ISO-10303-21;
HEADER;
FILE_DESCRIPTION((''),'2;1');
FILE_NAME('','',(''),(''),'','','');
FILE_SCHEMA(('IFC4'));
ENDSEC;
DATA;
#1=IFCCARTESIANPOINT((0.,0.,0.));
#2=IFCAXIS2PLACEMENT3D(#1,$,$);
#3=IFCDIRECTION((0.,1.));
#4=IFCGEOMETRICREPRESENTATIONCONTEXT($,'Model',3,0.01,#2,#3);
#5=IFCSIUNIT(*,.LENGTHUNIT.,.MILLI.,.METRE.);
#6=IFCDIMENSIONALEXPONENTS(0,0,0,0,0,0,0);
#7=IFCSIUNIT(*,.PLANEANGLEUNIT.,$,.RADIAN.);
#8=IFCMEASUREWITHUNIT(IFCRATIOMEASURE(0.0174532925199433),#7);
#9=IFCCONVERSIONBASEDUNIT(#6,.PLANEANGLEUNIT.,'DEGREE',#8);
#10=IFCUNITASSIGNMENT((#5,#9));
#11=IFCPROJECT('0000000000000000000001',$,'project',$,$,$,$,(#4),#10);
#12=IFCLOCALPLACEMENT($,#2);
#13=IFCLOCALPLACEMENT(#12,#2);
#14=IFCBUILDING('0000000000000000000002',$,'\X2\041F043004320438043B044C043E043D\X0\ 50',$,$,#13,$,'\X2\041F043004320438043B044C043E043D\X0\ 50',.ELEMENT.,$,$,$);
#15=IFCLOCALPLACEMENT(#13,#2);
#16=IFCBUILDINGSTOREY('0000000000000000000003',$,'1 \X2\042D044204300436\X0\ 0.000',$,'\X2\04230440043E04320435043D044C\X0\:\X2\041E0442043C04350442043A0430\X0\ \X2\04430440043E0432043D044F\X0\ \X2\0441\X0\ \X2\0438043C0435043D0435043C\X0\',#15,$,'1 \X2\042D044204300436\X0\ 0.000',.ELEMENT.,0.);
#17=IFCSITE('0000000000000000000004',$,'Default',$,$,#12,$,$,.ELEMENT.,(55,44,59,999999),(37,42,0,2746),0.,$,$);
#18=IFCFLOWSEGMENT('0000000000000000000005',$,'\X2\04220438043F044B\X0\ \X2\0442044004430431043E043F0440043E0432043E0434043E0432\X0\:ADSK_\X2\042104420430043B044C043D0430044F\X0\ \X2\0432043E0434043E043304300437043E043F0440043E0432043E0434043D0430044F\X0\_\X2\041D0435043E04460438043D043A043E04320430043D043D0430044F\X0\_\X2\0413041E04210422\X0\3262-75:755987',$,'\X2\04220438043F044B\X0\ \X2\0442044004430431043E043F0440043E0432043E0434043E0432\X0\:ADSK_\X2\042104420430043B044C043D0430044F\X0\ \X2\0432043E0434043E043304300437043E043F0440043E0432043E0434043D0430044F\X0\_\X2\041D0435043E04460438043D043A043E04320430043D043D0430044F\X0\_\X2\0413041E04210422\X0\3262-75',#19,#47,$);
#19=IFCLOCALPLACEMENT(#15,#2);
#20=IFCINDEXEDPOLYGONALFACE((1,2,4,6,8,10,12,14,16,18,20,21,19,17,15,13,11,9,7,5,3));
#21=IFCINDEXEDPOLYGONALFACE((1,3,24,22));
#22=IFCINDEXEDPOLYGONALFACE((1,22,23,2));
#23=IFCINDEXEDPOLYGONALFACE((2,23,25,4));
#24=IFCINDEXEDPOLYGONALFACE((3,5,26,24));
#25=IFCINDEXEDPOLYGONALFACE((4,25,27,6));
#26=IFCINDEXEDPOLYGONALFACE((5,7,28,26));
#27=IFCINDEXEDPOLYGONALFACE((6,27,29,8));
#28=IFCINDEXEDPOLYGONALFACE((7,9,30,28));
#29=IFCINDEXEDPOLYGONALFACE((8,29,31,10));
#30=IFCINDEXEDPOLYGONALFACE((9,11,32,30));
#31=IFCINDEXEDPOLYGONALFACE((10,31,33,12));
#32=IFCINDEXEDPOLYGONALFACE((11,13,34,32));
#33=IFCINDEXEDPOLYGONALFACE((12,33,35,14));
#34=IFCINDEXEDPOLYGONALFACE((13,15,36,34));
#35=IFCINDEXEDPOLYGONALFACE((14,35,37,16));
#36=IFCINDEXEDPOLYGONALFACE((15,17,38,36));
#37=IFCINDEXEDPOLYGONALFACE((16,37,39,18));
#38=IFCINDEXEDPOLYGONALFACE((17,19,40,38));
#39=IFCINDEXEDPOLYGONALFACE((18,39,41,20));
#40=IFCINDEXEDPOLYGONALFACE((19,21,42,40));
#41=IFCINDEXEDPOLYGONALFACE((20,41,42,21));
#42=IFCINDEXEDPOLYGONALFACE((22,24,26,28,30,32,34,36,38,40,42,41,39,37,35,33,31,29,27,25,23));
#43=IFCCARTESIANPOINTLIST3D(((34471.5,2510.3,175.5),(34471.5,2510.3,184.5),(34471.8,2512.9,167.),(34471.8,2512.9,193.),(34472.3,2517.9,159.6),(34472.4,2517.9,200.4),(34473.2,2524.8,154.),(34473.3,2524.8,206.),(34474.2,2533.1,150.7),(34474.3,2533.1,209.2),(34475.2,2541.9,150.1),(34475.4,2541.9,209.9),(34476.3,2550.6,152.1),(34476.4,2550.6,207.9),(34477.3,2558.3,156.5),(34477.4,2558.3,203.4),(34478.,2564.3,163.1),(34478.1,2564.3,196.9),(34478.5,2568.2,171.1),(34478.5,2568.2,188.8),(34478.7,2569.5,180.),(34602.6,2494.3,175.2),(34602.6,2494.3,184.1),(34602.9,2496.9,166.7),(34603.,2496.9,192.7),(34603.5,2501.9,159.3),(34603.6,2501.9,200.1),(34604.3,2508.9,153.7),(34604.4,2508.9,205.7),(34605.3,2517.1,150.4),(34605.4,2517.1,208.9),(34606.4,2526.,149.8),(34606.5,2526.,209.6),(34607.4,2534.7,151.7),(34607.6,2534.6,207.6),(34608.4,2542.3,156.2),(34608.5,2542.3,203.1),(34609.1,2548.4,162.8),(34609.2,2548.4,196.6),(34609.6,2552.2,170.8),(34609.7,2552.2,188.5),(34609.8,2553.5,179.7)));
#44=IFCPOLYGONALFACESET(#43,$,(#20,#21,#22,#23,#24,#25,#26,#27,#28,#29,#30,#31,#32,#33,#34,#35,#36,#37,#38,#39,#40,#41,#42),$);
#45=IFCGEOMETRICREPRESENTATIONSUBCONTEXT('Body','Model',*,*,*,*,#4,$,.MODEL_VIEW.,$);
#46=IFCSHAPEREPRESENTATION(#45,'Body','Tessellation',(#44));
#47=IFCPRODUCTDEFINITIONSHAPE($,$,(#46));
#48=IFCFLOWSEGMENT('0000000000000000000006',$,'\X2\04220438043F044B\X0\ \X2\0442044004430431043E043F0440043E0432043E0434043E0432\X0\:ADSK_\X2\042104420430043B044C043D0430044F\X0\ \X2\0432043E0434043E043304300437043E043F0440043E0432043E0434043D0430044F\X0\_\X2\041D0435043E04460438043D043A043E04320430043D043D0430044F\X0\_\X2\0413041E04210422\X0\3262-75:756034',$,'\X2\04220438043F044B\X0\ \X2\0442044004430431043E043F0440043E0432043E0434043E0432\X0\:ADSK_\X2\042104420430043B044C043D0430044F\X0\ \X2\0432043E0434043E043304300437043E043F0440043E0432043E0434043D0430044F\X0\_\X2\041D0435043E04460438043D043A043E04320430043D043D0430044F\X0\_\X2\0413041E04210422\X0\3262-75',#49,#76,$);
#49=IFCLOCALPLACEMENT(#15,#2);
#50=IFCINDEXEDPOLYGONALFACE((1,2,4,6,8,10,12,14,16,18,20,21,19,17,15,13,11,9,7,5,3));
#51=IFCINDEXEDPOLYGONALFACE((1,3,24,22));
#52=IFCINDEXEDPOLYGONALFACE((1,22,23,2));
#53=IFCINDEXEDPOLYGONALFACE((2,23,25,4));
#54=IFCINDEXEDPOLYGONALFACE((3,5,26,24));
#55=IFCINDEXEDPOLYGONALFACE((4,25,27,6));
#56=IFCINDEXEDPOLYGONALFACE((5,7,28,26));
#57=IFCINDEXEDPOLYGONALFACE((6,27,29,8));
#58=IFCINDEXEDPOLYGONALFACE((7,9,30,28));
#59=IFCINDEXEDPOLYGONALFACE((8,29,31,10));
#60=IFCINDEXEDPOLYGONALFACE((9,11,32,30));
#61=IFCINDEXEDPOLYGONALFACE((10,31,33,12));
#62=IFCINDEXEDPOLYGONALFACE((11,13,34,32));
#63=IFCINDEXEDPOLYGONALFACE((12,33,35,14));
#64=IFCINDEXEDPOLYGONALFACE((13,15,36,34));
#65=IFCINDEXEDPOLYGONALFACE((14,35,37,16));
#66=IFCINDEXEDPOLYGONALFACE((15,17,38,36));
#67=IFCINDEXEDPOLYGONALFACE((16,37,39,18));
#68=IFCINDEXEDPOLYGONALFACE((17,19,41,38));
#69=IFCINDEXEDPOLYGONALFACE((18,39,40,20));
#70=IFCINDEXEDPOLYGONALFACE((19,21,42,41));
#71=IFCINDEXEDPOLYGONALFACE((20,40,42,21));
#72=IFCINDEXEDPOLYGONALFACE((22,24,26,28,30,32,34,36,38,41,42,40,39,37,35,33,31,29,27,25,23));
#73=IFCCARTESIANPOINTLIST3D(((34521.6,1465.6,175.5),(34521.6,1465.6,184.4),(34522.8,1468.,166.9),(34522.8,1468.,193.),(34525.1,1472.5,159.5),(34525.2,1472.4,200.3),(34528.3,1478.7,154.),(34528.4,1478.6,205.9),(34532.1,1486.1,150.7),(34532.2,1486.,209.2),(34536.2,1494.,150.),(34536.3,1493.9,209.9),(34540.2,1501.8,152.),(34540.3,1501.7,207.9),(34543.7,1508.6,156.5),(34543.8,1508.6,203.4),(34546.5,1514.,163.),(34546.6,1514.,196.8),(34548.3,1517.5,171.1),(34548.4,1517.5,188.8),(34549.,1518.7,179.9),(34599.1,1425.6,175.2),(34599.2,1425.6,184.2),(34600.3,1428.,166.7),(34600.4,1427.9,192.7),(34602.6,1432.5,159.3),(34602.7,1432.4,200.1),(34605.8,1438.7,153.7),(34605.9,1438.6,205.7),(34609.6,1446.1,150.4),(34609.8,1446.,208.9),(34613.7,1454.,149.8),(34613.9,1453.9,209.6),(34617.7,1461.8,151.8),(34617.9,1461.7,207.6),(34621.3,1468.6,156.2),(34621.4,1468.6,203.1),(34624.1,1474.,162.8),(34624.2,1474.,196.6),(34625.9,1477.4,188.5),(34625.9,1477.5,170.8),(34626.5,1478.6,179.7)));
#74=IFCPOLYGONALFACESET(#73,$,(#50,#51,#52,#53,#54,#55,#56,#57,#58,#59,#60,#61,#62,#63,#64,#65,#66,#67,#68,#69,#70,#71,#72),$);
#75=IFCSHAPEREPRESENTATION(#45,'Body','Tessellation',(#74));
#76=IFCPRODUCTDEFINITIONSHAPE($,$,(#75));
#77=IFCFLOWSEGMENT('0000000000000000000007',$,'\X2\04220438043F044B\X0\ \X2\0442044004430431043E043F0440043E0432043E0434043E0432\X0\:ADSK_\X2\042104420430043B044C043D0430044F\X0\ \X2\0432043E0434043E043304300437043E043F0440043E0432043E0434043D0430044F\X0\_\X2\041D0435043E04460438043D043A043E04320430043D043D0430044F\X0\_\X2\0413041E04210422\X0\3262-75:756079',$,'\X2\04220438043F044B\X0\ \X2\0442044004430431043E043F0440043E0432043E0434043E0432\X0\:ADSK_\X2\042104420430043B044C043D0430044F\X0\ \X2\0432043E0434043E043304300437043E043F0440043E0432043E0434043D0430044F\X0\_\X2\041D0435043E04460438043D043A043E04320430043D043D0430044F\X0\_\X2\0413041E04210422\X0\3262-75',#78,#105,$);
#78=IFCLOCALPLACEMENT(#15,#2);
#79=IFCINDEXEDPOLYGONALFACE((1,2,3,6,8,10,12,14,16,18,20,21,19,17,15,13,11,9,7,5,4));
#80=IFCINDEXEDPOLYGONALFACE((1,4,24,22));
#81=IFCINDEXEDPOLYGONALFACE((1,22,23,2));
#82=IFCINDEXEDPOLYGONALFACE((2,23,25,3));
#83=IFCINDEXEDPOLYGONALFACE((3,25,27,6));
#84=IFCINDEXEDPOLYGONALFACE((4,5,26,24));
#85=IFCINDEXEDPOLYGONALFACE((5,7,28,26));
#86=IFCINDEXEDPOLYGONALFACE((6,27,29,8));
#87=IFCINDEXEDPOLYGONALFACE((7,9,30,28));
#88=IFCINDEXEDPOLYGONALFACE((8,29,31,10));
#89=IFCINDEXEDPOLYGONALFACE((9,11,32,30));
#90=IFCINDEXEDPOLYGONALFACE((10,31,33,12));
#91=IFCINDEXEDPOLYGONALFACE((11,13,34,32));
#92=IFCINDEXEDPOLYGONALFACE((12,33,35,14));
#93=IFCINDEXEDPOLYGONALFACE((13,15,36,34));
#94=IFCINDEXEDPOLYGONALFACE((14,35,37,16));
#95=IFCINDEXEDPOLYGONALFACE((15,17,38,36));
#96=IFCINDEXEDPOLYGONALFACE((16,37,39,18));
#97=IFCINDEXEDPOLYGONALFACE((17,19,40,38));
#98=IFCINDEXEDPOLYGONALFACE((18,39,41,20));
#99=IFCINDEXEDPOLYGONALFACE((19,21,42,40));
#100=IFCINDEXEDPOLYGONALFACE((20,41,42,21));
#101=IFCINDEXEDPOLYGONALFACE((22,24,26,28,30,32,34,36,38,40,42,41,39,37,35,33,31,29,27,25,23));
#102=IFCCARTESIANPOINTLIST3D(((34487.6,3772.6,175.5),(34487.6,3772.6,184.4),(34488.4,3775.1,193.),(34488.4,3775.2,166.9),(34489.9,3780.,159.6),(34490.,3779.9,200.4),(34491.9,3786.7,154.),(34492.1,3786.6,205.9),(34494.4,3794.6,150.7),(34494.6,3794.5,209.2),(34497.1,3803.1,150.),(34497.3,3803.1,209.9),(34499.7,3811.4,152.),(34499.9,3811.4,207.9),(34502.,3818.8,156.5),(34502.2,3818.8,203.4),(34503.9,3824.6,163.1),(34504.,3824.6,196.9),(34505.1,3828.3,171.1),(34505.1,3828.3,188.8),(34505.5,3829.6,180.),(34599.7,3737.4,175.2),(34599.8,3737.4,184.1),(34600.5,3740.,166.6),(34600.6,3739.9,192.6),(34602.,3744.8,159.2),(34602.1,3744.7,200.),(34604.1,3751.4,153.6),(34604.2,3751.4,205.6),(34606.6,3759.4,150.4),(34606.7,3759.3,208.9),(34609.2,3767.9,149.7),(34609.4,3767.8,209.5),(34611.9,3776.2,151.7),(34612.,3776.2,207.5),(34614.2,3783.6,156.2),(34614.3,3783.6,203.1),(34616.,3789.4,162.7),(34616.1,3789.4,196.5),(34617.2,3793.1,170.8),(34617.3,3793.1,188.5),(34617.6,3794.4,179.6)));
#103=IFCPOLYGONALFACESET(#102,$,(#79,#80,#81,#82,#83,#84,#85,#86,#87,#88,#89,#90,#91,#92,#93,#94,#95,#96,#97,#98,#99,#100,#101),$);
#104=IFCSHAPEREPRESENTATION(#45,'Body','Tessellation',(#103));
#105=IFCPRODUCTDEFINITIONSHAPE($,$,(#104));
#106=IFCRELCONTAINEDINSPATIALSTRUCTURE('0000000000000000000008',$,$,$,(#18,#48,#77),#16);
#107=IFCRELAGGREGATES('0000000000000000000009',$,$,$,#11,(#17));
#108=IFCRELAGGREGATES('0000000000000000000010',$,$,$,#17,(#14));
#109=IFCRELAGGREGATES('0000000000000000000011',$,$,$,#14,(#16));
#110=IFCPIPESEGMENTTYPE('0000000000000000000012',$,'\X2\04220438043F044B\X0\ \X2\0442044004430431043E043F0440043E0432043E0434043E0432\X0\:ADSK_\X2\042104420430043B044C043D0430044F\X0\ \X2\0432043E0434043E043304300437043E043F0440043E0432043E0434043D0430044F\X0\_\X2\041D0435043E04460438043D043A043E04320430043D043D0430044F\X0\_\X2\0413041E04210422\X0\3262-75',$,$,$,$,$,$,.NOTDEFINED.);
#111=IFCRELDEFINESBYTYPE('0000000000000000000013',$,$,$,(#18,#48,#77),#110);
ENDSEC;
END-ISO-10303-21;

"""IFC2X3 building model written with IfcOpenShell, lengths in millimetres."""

from ifc_helpers import new_model, entity, si_unit, converted_unit, direction, frame, frame_2d, origin, place, context, subcontext, project, spatial, circle, extrude, type_object, element, save


model = new_model("IFC2X3")

# Units and contexts
model_context = context("Model", 3, precision=0.01, world=origin(), true_north=direction((0.0, 1.0)))
body_context = subcontext(model_context, "Body", "Model", "MODEL_VIEW")
ifc_project = project(units=[si_unit("LENGTHUNIT", "METRE", prefix="MILLI"), converted_unit("PLANEANGLEUNIT", "DEGREE", entity("IfcRatioMeasure", 0.0174532925199433), si_unit("PLANEANGLEUNIT", "RADIAN"), dimensions=[0, 0, 0, 0, 0, 0, 0])], contexts=[model_context])

# Site, building, storey
site_placement = place(None, origin())
site = spatial("IfcSite", under=ifc_project, at=site_placement, Name="Default", CompositionType="ELEMENT", RefLatitude=(55, 44, 59, 999999), RefLongitude=(37, 42, 0, 2746), RefElevation=0.0)
building_placement = place(site_placement, origin())
building = spatial("IfcBuilding", under=site, at=building_placement, Name="Павильон 50", LongName="Павильон 50", CompositionType="ELEMENT")
storey_placement = place(building_placement, origin())
storey = spatial("IfcBuildingStorey", under=building, at=storey_placement, Name="1 Этаж 0.000", ObjectType="Уровень:Отметка уровня с именем", LongName="1 Этаж 0.000", CompositionType="ELEMENT", Elevation=0.0)

# Flow segments
pipe_segment_type = type_object("IfcPipeSegmentType", Name="Типы трубопроводов:ADSK_Стальная водогазопроводная_Неоцинкованная_ГОСТ3262-75", PredefinedType="NOTDEFINED")
flow_segment_1_placement = place(storey_placement, frame((34469.8, 2492.4, 148.1)))
element("IfcFlowSegment", 1, at=flow_segment_1_placement, inside=storey, type_object=pipe_segment_type, Name="Типы трубопроводов:ADSK_Стальная водогазопроводная_Неоцинкованная_ГОСТ3262-75:755987", ObjectType="Типы трубопроводов:ADSK_Стальная водогазопроводная_Неоцинкованная_ГОСТ3262-75", context=body_context, shape_type="SweptSolid", body=[
    extrude(circle(Radius=30.0, at=frame_2d((0.0, 0.0), x_axis=(1.0, 0.0))), frame((136.4, 31.4, 31.6), z_axis=(-0.992682, 0.120734, 0.00231), x_axis=(0.120735, 0.992685, 0.0)), (0.0, 0.0, 1.0), 132.1),
])
flow_segment_2_placement = place(storey_placement, frame((34519.9, 1423.7, 148.1)))
element("IfcFlowSegment", 2, at=flow_segment_2_placement, inside=storey, type_object=pipe_segment_type, Name="Типы трубопроводов:ADSK_Стальная водогазопроводная_Неоцинкованная_ГОСТ3262-75:756034", ObjectType="Типы трубопроводов:ADSK_Стальная водогазопроводная_Неоцинкованная_ГОСТ3262-75", context=body_context, shape_type="SweptSolid", body=[
    extrude(circle(Radius=30.0, at=frame_2d((0.0, 0.0), x_axis=(1.0, 0.0))), frame((92.9, 28.3, 31.6), z_axis=(-0.888678, 0.458523, 0.002968), x_axis=(0.458525, 0.888681, 0.0)), (0.0, 0.0, 1.0), 87.3),
])
flow_segment_3_placement = place(storey_placement, frame((34485.9, 3735.5, 148.0)))
element("IfcFlowSegment", 3, at=flow_segment_3_placement, inside=storey, type_object=pipe_segment_type, Name="Типы трубопроводов:ADSK_Стальная водогазопроводная_Неоцинкованная_ГОСТ3262-75:756079", ObjectType="Типы трубопроводов:ADSK_Стальная водогазопроводная_Неоцинкованная_ГОСТ3262-75", context=body_context, shape_type="SweptSolid", body=[
    extrude(circle(Radius=30.0, at=frame_2d((0.0, 0.0), x_axis=(1.0, 0.0))), frame((10.6, 65.4, 31.9), z_axis=(0.954086, -0.299519, -0.002881), x_axis=(0.29952, 0.95409, 0.0)), (0.0, 0.0, 1.0), 117.5),
])

save(model, "model.ifc")
